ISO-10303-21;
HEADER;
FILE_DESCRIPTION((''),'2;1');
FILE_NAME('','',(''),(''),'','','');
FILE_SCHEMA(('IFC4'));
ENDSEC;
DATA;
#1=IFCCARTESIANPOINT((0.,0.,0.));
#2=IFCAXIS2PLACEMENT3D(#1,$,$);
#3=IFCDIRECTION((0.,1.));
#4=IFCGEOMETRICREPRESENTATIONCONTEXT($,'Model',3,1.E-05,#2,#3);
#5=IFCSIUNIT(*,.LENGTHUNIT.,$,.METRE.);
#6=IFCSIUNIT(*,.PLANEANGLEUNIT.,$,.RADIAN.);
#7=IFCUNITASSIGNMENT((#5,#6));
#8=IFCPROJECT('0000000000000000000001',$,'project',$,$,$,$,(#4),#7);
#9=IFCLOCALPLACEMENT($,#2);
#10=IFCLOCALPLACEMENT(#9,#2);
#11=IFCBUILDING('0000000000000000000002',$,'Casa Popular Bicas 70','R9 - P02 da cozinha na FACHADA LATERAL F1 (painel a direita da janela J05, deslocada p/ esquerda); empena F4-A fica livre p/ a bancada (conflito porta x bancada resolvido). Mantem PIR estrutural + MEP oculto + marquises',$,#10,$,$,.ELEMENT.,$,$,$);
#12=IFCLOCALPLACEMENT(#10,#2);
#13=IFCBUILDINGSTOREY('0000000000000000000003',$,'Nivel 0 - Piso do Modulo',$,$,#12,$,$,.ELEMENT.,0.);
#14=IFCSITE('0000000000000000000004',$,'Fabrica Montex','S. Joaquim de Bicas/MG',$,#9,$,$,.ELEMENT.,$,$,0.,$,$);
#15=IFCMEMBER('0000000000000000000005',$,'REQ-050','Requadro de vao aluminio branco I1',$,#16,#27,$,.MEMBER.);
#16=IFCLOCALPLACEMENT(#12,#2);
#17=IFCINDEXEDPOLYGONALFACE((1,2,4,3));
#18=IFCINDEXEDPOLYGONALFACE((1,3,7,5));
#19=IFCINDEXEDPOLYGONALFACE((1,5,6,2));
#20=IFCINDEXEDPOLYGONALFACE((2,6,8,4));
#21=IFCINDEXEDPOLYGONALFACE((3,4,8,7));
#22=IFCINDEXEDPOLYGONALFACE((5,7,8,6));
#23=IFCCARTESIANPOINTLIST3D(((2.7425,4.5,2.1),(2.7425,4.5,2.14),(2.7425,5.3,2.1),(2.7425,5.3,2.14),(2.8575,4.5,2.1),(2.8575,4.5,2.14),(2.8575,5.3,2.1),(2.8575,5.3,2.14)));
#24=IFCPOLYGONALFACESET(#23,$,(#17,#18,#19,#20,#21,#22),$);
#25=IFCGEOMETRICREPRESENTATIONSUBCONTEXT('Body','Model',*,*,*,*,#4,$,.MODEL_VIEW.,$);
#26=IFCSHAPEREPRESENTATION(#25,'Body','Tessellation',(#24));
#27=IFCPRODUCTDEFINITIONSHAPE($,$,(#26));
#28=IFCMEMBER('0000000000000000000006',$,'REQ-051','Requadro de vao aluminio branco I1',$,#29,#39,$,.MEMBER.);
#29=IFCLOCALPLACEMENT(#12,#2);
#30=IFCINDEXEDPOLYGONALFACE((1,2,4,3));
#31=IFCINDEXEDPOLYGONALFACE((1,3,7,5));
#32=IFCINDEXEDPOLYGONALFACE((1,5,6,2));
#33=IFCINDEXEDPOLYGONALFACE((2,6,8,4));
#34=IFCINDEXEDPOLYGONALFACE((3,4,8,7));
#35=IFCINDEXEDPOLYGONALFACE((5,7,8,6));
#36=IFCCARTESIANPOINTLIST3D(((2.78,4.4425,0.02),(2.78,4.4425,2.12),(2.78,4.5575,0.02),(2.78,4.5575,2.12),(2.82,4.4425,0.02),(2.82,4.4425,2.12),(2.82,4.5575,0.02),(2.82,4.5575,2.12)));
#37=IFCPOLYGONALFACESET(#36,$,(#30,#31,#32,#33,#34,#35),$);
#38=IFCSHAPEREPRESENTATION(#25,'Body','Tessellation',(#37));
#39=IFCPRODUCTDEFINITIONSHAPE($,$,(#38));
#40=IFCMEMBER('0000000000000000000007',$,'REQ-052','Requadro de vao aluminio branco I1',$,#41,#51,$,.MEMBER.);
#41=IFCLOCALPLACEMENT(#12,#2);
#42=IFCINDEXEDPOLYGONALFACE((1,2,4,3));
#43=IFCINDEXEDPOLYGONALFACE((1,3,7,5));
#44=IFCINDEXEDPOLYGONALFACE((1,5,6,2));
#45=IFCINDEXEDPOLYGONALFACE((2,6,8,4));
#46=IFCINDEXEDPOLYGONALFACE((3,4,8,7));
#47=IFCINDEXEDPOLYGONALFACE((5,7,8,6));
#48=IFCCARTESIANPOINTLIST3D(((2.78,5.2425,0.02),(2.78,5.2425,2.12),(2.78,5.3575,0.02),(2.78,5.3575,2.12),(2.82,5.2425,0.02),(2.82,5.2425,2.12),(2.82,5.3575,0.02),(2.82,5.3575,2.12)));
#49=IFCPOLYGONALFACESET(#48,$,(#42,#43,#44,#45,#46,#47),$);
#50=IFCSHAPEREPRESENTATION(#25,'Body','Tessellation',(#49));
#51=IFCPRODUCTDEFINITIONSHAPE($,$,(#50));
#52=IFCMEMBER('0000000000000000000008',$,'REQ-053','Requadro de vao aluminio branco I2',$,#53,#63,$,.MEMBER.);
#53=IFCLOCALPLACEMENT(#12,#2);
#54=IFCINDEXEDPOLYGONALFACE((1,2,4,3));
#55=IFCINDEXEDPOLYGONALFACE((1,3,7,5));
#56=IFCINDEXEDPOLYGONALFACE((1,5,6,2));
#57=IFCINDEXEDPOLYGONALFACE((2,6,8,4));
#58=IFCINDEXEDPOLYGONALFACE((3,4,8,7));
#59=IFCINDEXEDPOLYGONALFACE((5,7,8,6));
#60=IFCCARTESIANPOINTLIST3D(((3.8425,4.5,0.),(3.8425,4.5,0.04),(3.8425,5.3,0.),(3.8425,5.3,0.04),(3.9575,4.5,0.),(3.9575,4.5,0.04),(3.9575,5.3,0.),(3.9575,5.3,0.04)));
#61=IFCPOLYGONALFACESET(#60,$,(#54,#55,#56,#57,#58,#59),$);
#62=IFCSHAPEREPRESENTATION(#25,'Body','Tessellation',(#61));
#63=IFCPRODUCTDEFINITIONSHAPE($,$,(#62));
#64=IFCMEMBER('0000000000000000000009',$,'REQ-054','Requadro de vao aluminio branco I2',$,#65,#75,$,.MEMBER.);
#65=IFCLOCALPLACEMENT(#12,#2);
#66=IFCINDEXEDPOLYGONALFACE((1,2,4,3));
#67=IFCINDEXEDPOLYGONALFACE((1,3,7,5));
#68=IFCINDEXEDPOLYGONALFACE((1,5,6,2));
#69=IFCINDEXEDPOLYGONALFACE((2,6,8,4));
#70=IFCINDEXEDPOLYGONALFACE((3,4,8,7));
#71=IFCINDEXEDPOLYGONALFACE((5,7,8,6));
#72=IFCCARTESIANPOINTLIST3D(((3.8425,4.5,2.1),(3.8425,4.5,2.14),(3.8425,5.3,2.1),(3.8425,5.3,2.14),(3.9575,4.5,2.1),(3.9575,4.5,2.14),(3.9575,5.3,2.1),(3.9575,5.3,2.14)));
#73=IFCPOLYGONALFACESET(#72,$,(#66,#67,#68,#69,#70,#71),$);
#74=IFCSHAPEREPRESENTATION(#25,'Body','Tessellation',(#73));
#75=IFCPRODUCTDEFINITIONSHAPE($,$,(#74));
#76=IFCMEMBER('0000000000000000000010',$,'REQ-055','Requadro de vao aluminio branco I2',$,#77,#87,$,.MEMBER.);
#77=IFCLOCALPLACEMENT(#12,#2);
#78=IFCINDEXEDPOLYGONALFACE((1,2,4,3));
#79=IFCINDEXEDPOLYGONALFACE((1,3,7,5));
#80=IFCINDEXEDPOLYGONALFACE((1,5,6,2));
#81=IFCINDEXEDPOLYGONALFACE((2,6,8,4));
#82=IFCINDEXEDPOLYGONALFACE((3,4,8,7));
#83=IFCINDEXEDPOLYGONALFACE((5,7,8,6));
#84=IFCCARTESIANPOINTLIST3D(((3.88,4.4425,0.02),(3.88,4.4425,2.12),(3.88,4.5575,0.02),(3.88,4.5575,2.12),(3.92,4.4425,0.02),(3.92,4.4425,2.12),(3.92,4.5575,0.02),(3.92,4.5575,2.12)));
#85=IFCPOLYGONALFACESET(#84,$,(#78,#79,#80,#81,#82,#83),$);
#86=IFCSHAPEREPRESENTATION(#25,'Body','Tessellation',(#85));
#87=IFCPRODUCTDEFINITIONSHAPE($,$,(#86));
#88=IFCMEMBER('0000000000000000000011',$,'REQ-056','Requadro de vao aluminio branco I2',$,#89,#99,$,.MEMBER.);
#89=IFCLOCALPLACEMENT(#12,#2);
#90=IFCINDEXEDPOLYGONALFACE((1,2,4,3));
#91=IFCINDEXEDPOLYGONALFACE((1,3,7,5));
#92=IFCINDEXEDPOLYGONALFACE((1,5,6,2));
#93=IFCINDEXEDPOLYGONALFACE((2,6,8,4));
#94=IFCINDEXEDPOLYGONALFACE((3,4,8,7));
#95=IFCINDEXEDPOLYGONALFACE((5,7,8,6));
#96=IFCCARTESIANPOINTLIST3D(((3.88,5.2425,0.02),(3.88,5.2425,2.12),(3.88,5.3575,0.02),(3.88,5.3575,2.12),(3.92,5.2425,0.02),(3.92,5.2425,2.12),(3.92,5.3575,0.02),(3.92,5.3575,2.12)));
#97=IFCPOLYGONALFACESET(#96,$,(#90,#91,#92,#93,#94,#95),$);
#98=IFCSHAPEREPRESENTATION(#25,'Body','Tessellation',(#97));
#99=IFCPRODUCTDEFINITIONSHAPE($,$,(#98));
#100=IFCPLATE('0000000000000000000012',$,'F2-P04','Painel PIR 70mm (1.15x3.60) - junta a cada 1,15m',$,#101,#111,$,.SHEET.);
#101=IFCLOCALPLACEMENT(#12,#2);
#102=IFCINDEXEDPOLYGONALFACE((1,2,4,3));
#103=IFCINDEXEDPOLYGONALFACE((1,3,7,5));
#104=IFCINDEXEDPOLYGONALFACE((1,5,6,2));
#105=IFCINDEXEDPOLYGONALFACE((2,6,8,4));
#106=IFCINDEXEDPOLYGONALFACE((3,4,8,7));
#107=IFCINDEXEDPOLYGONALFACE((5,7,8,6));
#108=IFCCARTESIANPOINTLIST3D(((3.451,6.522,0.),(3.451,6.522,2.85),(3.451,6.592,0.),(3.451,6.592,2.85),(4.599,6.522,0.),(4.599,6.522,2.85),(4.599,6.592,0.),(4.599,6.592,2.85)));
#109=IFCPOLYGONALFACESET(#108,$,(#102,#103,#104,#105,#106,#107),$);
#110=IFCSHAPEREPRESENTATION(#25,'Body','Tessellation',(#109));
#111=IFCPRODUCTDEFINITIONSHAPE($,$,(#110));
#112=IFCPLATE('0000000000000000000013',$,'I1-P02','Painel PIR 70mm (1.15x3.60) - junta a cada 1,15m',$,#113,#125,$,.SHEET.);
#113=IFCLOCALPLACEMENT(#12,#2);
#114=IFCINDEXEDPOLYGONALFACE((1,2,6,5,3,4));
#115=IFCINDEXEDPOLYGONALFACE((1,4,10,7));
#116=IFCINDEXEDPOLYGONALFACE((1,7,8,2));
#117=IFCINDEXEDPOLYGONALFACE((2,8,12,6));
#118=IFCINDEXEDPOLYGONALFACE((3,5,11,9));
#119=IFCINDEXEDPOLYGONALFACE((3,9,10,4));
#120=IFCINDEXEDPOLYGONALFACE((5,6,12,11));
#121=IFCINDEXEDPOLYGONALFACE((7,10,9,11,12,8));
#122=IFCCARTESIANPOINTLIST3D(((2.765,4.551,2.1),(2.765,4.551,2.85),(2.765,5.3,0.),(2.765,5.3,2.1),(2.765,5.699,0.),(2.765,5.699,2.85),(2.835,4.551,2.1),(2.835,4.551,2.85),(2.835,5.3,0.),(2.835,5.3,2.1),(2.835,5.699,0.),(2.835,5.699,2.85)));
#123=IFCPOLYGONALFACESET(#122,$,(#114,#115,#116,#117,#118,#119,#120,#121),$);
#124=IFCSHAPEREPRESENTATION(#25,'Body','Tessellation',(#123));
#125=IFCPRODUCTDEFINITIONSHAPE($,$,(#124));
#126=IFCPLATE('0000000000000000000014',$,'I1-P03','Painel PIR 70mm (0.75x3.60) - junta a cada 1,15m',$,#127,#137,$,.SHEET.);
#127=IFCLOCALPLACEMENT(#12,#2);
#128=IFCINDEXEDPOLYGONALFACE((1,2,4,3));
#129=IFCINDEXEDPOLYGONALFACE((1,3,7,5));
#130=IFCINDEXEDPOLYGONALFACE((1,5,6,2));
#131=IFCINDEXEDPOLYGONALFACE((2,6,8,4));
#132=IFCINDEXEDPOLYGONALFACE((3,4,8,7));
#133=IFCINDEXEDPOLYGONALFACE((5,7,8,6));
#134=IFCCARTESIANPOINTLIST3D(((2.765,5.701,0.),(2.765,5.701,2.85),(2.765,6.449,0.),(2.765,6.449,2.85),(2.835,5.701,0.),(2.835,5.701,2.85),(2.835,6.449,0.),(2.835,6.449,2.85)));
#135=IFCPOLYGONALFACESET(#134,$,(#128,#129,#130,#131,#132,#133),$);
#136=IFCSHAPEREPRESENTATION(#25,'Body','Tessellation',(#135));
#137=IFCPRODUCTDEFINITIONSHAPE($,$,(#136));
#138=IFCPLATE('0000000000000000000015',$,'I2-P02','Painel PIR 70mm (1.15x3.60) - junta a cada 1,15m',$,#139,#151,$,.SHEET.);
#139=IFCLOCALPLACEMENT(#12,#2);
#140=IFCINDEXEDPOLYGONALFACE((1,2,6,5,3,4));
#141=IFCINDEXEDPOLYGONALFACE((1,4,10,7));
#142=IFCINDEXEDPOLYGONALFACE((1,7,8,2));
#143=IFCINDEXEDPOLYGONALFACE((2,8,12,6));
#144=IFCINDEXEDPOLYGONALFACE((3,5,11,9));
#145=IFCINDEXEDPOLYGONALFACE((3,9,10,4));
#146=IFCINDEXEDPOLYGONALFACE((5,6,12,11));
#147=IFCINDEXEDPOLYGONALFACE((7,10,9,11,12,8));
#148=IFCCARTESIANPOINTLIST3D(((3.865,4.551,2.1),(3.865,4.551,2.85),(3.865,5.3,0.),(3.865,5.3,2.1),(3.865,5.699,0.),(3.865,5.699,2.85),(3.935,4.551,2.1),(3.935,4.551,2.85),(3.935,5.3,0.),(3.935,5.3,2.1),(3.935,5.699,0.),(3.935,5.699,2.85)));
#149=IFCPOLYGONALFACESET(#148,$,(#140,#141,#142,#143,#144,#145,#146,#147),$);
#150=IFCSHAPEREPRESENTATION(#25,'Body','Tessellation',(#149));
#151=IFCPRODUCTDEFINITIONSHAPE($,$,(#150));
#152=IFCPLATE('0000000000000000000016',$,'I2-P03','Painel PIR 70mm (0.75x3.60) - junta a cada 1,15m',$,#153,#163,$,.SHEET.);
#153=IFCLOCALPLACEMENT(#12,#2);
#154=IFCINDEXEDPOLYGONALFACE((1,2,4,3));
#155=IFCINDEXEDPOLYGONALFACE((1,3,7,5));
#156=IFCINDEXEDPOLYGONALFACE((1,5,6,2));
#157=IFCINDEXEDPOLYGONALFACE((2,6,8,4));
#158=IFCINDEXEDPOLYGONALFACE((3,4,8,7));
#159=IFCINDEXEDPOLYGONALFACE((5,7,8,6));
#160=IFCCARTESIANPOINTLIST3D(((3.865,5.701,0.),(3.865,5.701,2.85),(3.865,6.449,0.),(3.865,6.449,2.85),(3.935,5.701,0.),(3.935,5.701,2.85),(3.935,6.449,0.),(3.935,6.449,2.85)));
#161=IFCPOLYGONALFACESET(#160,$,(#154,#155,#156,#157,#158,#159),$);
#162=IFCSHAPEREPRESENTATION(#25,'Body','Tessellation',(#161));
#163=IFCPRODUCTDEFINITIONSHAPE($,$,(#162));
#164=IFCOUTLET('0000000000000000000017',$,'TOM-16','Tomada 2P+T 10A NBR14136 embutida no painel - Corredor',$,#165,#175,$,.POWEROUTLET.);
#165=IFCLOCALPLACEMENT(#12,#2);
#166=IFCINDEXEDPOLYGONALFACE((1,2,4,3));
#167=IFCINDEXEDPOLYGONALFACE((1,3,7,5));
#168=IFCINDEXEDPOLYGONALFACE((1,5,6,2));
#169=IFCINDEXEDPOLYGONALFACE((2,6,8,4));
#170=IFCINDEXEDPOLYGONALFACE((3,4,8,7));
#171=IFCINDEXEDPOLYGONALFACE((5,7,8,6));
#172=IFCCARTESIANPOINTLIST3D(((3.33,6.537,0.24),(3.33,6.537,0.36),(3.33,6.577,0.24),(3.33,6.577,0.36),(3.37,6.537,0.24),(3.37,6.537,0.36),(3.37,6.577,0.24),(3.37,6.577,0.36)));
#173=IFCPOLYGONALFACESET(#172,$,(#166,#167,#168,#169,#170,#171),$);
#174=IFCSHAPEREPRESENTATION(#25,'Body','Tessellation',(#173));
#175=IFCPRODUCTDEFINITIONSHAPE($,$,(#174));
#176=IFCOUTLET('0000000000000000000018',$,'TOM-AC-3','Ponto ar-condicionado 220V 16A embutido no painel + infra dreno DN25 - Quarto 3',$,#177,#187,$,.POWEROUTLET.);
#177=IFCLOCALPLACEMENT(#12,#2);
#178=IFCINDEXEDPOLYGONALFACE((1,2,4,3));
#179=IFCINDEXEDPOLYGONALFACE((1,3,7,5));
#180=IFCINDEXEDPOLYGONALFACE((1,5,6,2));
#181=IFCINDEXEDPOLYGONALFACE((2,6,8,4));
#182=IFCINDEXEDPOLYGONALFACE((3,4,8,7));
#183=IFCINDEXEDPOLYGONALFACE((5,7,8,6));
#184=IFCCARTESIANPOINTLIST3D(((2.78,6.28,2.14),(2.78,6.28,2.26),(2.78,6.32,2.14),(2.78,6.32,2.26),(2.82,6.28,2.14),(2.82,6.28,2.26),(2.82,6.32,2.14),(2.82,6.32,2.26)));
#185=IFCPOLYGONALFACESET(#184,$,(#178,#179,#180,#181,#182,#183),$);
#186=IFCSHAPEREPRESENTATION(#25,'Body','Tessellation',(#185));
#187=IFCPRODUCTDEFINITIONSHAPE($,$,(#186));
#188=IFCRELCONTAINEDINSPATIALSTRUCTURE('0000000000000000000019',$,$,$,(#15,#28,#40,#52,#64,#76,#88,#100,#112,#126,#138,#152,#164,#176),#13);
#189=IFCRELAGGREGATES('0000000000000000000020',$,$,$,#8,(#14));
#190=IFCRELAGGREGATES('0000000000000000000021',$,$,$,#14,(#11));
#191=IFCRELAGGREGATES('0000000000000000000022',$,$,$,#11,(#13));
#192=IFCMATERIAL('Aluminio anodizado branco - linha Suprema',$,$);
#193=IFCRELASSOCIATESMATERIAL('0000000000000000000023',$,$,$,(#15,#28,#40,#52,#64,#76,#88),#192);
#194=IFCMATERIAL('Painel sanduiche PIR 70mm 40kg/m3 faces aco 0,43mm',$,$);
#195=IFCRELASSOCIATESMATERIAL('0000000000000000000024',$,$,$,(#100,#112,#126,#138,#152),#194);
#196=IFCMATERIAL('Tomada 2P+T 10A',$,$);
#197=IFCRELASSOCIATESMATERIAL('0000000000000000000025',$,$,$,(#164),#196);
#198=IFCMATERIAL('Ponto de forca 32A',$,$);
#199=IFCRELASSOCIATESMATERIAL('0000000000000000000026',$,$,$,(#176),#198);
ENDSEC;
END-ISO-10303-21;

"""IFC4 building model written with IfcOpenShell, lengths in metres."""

from ifc_helpers import new_model, si_unit, direction, frame, frame_2d, origin, origin_2d, place, context, subcontext, project, spatial, rectangle, extrude, material, element, save


model = new_model("IFC4")

# Units and contexts
model_context = context("Model", 3, precision=1e-05, world=origin(), true_north=direction((0.0, 1.0)))
body_context = subcontext(model_context, "Body", "Model", "MODEL_VIEW")
ifc_project = project(units=[si_unit("LENGTHUNIT", "METRE"), si_unit("PLANEANGLEUNIT", "RADIAN")], contexts=[model_context])

# Site, building, storey
site_placement = place(None, origin())
site = spatial("IfcSite", under=ifc_project, at=site_placement, Name="Fabrica Montex", Description="S. Joaquim de Bicas/MG", CompositionType="ELEMENT", RefElevation=0.0)
building_placement = place(site_placement, origin())
building = spatial("IfcBuilding", under=site, at=building_placement, Name="Casa Popular Bicas 70", Description="R9 - P02 da cozinha na FACHADA LATERAL F1 (painel a direita da janela J05, deslocada p/ esquerda); empena F4-A fica livre p/ a bancada (conflito porta x bancada resolvido). Mantem PIR estrutural + MEP oculto + marquises", CompositionType="ELEMENT")
storey_placement = place(building_placement, origin())
storey = spatial("IfcBuildingStorey", under=building, at=storey_placement, Name="Nivel 0 - Piso do Modulo", CompositionType="ELEMENT", Elevation=0.0)

# Members
ifc_material_1 = material(Name="Aluminio anodizado branco - linha Suprema")
member_placement = place(storey_placement, frame((2.8, 4.5, 2.12), z_axis=(0.0, 1.0, 0.0), x_axis=(0.0, 0.0, 1.0)))
element("IfcMember", 1, at=member_placement, inside=storey, material=ifc_material_1, Name="REQ-050", Description="Requadro de vao aluminio branco I1", PredefinedType="MEMBER", context=body_context, shape_type="SweptSolid", body=[
    extrude(rectangle(XDim=0.04, YDim=0.115, at=origin_2d()), origin(), (0.0, 0.0, 1.0), 0.8),
])
for number, where, z_axis, x_axis, name in (
    (2, (2.8, 4.5, 0.02), (0.0, 0.0, 1.0), (1.0, 0.0, 0.0), "REQ-051"),
    (3, (2.8, 5.3, 0.02), (0.0, 0.0, 1.0), (1.0, 0.0, 0.0), "REQ-052"),
):
    element("IfcMember", number, at=place(storey_placement, frame(where, z_axis=z_axis, x_axis=x_axis)), inside=storey, material=ifc_material_1, Name=name, Description="Requadro de vao aluminio branco I1", PredefinedType="MEMBER", context=body_context, shape_type="SweptSolid", body=[
        extrude(rectangle(XDim=0.04, YDim=0.115, at=origin_2d()), origin(), (0.0, 0.0, 1.0), 2.1),
    ])
for number, where, z_axis, x_axis, name in (
    (4, (3.9, 4.5, 0.02), (0.0, 1.0, 0.0), (0.0, 0.0, 1.0), "REQ-053"),
    (5, (3.9, 4.5, 2.12), (0.0, 1.0, 0.0), (0.0, 0.0, 1.0), "REQ-054"),
):
    element("IfcMember", number, at=place(storey_placement, frame(where, z_axis=z_axis, x_axis=x_axis)), inside=storey, material=ifc_material_1, Name=name, Description="Requadro de vao aluminio branco I2", PredefinedType="MEMBER", context=body_context, shape_type="SweptSolid", body=[
        extrude(rectangle(XDim=0.04, YDim=0.115, at=origin_2d()), origin(), (0.0, 0.0, 1.0), 0.8),
    ])
for number, where, z_axis, x_axis, name in (
    (6, (3.9, 4.5, 0.02), (0.0, 0.0, 1.0), (1.0, 0.0, 0.0), "REQ-055"),
    (7, (3.9, 5.3, 0.02), (0.0, 0.0, 1.0), (1.0, 0.0, 0.0), "REQ-056"),
):
    element("IfcMember", number, at=place(storey_placement, frame(where, z_axis=z_axis, x_axis=x_axis)), inside=storey, material=ifc_material_1, Name=name, Description="Requadro de vao aluminio branco I2", PredefinedType="MEMBER", context=body_context, shape_type="SweptSolid", body=[
        extrude(rectangle(XDim=0.04, YDim=0.115, at=origin_2d()), origin(), (0.0, 0.0, 1.0), 2.1),
    ])

# Plate
ifc_material_2 = material(Name="Painel sanduiche PIR 70mm 40kg/m3 faces aco 0,43mm")
plate_1_placement = place(storey_placement, frame((3.451, 6.557, 0.0), x_axis=(1.0, 0.0, 0.0)))
element("IfcPlate", 8, at=plate_1_placement, inside=storey, material=ifc_material_2, Name="F2-P04", Description="Painel PIR 70mm (1.15x3.60) - junta a cada 1,15m", PredefinedType="SHEET", context=body_context, shape_type="SweptSolid", body=[
    extrude(rectangle(XDim=1.148, YDim=0.07, at=frame_2d((0.574, 0.0))), origin(), (0.0, 0.0, 1.0), 2.85),
])

# Plate, opening
plate_2_placement = place(storey_placement, frame((2.8, 4.551, 0.0), x_axis=(0.0, 1.0, 0.0)))
plate_2 = element("IfcPlate", 9, at=plate_2_placement, inside=storey, material=ifc_material_2, Name="I1-P02", Description="Painel PIR 70mm (1.15x3.60) - junta a cada 1,15m", PredefinedType="SHEET", context=body_context, shape_type="SweptSolid", body=[
    extrude(rectangle(XDim=1.148, YDim=0.07, at=frame_2d((0.574, 0.0))), origin(), (0.0, 0.0, 1.0), 2.85),
])
opening_1_placement = place(storey_placement, frame((2.8, 4.925, 0.0)))
element("IfcOpeningElement", 10, at=opening_1_placement, cuts=plate_2, PredefinedType="OPENING", context=body_context, shape_type="SweptSolid", body=[
    extrude(rectangle(XDim=0.1, YDim=0.75, at=origin_2d()), origin(), (0.0, 0.0, 1.0), 2.1),
])

# Plate
plate_3_placement = place(storey_placement, frame((2.8, 5.701, 0.0), x_axis=(0.0, 1.0, 0.0)))
element("IfcPlate", 11, at=plate_3_placement, inside=storey, material=ifc_material_2, Name="I1-P03", Description="Painel PIR 70mm (0.75x3.60) - junta a cada 1,15m", PredefinedType="SHEET", context=body_context, shape_type="SweptSolid", body=[
    extrude(rectangle(XDim=0.748, YDim=0.07, at=frame_2d((0.374, 0.0))), origin(), (0.0, 0.0, 1.0), 2.85),
])

# Plate, opening
plate_4_placement = place(storey_placement, frame((3.9, 4.551, 0.0), x_axis=(0.0, 1.0, 0.0)))
plate_4 = element("IfcPlate", 12, at=plate_4_placement, inside=storey, material=ifc_material_2, Name="I2-P02", Description="Painel PIR 70mm (1.15x3.60) - junta a cada 1,15m", PredefinedType="SHEET", context=body_context, shape_type="SweptSolid", body=[
    extrude(rectangle(XDim=1.148, YDim=0.07, at=frame_2d((0.574, 0.0))), origin(), (0.0, 0.0, 1.0), 2.85),
])
opening_2_placement = place(storey_placement, frame((3.9, 4.925, 0.0)))
element("IfcOpeningElement", 13, at=opening_2_placement, cuts=plate_4, PredefinedType="OPENING", context=body_context, shape_type="SweptSolid", body=[
    extrude(rectangle(XDim=0.1, YDim=0.75, at=origin_2d()), origin(), (0.0, 0.0, 1.0), 2.1),
])

# Plate
plate_5_placement = place(storey_placement, frame((3.9, 5.701, 0.0), x_axis=(0.0, 1.0, 0.0)))
element("IfcPlate", 14, at=plate_5_placement, inside=storey, material=ifc_material_2, Name="I2-P03", Description="Painel PIR 70mm (0.75x3.60) - junta a cada 1,15m", PredefinedType="SHEET", context=body_context, shape_type="SweptSolid", body=[
    extrude(rectangle(XDim=0.748, YDim=0.07, at=frame_2d((0.374, 0.0))), origin(), (0.0, 0.0, 1.0), 2.85),
])

# Outlets
ifc_material_3 = material(Name="Tomada 2P+T 10A")
outlet_1_placement = place(storey_placement, frame((3.33, 6.537, 0.24)))
element("IfcOutlet", 15, at=outlet_1_placement, inside=storey, material=ifc_material_3, Name="TOM-16", Description="Tomada 2P+T 10A NBR14136 embutida no painel - Corredor", PredefinedType="POWEROUTLET", context=body_context, shape_type="SweptSolid", body=[
    extrude(rectangle(XDim=0.04, YDim=0.04, at=frame_2d((0.02, 0.02))), origin(), (0.0, 0.0, 1.0), 0.12),
])
ifc_material_4 = material(Name="Ponto de forca 32A")
outlet_2_placement = place(storey_placement, frame((2.78, 6.28, 2.14)))
element("IfcOutlet", 16, at=outlet_2_placement, inside=storey, material=ifc_material_4, Name="TOM-AC-3", Description="Ponto ar-condicionado 220V 16A embutido no painel + infra dreno DN25 - Quarto 3", PredefinedType="POWEROUTLET", context=body_context, shape_type="SweptSolid", body=[
    extrude(rectangle(XDim=0.04, YDim=0.04, at=frame_2d((0.02, 0.02))), origin(), (0.0, 0.0, 1.0), 0.12),
])

save(model, "model.ifc")
